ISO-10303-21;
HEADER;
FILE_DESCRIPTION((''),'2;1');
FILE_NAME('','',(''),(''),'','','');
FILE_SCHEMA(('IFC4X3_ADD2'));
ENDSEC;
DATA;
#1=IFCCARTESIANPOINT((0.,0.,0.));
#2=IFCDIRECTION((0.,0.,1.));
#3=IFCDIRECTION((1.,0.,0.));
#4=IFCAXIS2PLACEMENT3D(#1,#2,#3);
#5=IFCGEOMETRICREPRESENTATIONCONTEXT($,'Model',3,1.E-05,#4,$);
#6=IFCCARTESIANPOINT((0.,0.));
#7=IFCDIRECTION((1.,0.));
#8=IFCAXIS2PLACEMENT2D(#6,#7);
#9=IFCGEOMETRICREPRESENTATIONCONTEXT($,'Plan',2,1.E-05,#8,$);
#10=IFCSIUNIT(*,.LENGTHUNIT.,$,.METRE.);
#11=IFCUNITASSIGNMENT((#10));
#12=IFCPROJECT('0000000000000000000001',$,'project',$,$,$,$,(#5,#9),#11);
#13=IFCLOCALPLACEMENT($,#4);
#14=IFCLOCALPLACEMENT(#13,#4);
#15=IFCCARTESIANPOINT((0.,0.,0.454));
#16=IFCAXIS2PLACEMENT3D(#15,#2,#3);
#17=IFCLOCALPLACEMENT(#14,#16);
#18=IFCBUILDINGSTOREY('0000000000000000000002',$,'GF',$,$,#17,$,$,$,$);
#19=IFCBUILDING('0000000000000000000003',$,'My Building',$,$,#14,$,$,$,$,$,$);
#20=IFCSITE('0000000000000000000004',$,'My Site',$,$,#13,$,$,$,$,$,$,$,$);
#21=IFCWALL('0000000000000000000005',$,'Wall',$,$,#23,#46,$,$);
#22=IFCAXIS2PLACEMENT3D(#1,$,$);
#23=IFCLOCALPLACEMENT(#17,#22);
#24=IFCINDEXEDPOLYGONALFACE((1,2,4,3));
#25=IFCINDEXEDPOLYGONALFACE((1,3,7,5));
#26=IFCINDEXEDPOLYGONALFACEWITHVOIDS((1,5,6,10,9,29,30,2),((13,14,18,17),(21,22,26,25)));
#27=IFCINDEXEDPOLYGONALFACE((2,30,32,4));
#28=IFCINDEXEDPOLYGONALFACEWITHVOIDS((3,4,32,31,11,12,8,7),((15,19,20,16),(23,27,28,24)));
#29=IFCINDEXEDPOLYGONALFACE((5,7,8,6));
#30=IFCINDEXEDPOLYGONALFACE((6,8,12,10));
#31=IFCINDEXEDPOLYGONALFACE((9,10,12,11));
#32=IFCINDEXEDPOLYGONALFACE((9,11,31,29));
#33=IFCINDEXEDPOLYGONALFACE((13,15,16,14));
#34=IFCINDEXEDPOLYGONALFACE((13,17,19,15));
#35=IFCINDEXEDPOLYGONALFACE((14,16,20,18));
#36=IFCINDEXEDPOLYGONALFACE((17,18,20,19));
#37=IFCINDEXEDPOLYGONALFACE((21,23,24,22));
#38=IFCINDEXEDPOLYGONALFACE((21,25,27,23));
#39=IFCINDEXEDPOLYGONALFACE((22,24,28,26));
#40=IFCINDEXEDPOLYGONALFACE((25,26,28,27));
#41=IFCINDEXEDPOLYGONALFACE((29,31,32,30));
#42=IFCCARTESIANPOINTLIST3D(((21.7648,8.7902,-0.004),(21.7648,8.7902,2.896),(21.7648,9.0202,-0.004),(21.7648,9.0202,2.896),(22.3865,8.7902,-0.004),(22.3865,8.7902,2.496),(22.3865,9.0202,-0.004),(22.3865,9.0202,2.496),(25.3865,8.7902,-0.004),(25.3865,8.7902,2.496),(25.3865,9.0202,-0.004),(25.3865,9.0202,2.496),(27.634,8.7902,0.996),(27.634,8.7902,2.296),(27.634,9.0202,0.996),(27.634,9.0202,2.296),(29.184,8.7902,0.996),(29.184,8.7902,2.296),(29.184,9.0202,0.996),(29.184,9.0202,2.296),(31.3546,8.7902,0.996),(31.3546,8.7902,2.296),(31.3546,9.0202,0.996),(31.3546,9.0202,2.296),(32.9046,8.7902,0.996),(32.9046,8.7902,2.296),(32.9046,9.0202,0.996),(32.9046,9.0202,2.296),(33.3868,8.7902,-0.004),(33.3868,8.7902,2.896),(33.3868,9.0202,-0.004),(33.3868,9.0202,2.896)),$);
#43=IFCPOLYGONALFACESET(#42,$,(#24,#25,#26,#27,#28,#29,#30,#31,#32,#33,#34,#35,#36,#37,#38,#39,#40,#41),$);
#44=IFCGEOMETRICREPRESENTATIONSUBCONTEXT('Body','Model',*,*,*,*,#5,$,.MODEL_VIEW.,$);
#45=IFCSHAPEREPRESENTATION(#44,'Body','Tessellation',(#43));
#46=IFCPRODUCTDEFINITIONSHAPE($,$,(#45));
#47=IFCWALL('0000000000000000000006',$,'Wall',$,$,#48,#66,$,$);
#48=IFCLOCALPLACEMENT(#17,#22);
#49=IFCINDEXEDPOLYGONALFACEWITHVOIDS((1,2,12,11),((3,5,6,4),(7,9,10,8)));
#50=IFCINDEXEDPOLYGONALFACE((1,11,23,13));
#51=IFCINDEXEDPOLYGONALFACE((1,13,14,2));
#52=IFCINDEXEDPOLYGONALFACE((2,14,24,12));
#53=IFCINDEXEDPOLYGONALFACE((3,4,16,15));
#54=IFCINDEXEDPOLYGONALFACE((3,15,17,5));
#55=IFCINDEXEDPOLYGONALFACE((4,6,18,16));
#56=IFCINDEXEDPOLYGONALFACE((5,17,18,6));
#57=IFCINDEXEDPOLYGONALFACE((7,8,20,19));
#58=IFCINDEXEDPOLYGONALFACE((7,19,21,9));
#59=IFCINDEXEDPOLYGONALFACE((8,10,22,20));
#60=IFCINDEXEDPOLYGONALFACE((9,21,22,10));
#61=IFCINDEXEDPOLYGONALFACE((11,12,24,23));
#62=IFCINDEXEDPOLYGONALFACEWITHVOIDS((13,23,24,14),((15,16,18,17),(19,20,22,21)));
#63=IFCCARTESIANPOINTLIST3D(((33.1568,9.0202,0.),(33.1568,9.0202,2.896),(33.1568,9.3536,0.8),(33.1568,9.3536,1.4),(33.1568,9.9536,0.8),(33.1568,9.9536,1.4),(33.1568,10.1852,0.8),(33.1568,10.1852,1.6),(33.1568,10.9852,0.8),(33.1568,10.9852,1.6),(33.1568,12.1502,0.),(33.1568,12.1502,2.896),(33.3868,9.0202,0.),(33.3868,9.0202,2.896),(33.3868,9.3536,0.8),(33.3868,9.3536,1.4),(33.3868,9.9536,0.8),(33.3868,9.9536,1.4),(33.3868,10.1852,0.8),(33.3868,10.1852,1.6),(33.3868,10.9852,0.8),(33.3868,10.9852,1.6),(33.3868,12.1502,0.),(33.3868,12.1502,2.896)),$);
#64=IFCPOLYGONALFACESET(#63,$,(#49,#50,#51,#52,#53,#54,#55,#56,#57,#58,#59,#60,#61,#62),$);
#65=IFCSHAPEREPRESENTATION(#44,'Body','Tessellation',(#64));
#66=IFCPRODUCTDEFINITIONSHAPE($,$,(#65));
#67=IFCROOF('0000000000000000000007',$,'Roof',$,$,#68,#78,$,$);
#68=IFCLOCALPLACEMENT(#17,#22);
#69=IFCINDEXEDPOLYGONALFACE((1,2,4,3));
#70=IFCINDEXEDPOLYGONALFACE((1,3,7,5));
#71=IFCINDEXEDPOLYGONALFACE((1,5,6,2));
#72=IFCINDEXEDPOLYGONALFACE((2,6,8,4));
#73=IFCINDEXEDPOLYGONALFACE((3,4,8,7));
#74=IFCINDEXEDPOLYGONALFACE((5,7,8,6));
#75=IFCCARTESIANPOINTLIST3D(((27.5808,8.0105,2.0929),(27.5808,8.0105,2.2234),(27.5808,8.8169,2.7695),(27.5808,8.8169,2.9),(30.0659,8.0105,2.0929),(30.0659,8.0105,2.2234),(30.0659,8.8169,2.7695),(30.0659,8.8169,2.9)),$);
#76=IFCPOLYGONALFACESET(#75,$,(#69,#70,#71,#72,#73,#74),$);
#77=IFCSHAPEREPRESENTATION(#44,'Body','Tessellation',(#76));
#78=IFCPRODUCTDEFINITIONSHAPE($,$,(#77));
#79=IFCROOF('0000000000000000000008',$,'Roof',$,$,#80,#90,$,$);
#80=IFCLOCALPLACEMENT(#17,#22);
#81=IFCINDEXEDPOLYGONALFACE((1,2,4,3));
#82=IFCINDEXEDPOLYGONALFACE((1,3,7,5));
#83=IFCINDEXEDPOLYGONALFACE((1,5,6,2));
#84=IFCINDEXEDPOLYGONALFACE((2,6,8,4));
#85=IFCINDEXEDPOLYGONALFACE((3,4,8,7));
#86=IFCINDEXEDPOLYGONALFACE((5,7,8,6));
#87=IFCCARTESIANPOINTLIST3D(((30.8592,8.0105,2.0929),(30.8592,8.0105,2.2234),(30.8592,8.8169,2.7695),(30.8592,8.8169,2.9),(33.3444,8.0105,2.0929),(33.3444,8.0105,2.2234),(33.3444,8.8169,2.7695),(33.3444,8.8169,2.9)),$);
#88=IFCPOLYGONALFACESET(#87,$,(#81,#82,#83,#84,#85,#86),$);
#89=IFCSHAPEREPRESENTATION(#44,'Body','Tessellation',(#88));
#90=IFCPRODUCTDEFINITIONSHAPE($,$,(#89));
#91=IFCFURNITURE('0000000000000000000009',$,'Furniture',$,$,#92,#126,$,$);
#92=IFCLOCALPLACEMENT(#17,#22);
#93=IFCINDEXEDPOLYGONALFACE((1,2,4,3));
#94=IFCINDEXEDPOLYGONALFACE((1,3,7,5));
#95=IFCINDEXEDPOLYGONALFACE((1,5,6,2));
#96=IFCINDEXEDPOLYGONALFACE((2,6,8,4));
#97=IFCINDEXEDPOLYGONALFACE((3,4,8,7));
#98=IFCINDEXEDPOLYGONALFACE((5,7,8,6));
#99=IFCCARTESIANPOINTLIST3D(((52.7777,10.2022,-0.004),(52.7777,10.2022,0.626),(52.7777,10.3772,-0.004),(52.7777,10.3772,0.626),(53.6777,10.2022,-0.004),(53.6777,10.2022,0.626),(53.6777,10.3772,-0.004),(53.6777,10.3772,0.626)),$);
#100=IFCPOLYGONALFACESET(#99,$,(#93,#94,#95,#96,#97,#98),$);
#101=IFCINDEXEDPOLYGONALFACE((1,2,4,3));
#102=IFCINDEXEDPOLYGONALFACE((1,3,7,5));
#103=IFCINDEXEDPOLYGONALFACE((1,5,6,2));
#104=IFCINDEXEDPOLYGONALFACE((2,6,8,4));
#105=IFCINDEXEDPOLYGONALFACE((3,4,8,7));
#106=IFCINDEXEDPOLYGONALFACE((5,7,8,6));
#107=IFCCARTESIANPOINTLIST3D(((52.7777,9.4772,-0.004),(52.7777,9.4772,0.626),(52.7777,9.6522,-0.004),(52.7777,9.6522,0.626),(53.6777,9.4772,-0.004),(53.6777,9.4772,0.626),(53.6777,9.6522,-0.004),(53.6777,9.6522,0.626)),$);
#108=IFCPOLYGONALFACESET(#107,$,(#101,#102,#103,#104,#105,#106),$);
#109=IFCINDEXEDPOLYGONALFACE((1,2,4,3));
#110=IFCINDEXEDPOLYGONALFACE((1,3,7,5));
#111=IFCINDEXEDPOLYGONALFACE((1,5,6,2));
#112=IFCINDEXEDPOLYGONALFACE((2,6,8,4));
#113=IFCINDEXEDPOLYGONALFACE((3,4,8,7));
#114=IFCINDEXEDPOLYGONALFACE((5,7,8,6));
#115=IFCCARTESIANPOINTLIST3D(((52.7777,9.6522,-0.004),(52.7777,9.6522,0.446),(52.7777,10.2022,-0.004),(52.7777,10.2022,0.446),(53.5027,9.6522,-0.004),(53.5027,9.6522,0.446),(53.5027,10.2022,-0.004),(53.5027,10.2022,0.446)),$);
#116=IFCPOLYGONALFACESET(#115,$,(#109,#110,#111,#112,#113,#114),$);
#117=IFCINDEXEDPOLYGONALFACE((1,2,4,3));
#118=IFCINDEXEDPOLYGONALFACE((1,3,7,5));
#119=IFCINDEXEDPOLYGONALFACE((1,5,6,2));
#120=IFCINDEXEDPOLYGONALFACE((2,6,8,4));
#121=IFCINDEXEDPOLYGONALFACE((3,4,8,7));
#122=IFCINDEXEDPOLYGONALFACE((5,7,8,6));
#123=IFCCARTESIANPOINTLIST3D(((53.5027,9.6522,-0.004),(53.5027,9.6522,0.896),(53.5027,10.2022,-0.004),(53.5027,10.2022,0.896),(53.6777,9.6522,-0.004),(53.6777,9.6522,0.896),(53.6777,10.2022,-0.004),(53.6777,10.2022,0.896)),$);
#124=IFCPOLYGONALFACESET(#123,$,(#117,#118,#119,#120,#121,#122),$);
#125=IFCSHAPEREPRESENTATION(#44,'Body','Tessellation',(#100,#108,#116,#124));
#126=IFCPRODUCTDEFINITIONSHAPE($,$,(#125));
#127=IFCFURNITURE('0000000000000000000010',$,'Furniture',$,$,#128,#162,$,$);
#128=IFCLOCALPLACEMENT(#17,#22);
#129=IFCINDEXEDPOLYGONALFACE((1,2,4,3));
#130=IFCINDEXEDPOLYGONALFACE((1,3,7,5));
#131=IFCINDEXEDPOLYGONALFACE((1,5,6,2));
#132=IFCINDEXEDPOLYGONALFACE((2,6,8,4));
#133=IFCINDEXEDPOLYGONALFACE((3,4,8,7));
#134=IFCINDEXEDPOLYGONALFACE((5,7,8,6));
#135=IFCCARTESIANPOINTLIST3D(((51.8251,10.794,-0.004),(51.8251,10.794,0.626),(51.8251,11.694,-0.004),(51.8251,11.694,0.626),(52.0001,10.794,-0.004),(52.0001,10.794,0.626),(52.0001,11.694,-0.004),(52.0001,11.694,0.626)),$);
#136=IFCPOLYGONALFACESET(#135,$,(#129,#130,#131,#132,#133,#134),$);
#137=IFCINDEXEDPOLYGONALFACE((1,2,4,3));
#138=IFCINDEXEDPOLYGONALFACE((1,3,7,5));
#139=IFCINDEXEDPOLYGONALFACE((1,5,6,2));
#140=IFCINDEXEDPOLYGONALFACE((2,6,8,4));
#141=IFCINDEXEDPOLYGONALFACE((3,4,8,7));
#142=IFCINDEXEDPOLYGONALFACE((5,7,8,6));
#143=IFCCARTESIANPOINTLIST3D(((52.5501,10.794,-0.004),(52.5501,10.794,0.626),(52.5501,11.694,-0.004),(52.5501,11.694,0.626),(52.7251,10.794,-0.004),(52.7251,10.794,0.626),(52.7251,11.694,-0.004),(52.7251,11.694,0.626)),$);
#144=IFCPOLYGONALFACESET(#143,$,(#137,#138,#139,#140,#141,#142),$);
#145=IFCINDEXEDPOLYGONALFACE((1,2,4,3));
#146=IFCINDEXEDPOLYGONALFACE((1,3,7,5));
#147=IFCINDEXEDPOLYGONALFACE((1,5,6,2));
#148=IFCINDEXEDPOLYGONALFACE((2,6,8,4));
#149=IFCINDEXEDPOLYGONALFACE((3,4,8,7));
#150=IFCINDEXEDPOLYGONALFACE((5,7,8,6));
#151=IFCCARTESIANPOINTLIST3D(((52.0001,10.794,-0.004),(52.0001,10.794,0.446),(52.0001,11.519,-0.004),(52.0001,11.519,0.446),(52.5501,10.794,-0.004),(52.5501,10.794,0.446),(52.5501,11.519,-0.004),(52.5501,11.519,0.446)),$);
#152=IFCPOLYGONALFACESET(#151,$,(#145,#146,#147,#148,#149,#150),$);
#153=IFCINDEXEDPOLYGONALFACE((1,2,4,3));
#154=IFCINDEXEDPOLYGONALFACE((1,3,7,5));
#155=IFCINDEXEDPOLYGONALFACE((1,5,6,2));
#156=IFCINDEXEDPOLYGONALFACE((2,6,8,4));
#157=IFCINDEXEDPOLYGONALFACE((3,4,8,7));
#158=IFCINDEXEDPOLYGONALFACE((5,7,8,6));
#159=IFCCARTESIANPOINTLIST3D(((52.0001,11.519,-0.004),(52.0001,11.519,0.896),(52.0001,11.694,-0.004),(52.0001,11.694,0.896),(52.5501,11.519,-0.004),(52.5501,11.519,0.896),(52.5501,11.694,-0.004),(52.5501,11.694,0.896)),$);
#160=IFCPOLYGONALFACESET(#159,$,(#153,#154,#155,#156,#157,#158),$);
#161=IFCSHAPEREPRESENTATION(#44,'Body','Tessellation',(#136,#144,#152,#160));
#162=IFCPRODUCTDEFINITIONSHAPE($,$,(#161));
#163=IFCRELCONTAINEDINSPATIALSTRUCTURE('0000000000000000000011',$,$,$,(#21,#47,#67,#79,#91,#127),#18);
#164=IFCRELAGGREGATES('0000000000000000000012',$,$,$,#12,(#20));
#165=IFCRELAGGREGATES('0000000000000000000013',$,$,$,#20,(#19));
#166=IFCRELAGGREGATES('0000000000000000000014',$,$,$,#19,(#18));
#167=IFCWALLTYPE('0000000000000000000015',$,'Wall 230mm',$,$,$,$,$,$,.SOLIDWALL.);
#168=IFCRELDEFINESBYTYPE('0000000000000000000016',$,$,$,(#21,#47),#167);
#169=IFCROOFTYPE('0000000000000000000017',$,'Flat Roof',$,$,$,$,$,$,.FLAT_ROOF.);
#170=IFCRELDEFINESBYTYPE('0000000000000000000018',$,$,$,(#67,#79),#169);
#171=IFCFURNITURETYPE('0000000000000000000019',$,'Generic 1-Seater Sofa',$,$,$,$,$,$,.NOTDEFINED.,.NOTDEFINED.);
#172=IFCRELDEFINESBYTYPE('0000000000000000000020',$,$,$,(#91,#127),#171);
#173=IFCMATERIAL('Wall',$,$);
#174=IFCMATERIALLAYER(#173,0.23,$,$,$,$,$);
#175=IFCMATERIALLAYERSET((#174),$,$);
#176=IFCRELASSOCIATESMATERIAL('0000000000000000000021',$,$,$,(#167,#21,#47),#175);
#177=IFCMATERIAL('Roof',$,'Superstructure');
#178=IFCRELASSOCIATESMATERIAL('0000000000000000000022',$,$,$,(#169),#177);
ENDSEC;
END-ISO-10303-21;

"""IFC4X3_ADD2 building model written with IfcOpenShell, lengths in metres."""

from ifc_helpers import new_model, entity, si_unit, frame, origin_with_axes, origin_2d_with_axis, place, context, subcontext, project, spatial, polyline, line, indexed_curve, outline, extrude, clip, halfspace, shape, source, transform, mapped, material, layer, layer_set, layer_usage, type_object, type_shapes, element, save


model = new_model("IFC4X3_ADD2")

# Units and contexts
model_context = context("Model", 3, precision=1e-05, world=origin_with_axes())
plan_context = context("Plan", 2, precision=1e-05, world=origin_2d_with_axis())
body_context_1 = subcontext(model_context, "Body", "Model", "MODEL_VIEW")
body_context_2 = subcontext(plan_context, "Body", "Plan", "PLAN_VIEW")
ifc_project = project(units=[si_unit("LENGTHUNIT", "METRE")], contexts=[model_context, plan_context])

# Site, building, storey
site_placement = place(None, origin_with_axes())
site = spatial("IfcSite", under=ifc_project, at=site_placement, Name="My Site")
building_placement = place(site_placement, origin_with_axes())
building = spatial("IfcBuilding", under=site, at=building_placement, Name="My Building")
storey_placement = place(building_placement, frame((0.0, 0.0, 0.454), z_axis=(0.0, 0.0, 1.0), x_axis=(1.0, 0.0, 0.0)))
storey = spatial("IfcBuildingStorey", under=building, at=storey_placement, Name="GF")

# Walls, openings
ifc_material_1 = material(Name="Wall")
ifc_layer = layer(ifc_material_1, 0.23)
ifc_layer_set = layer_set([ifc_layer])
ifc_layer_usage_1 = layer_usage(ifc_layer_set, "AXIS2", "POSITIVE", 0.0)
wall_type = type_object("IfcWallType", Name="Wall 230mm", PredefinedType="SOLIDWALL", material=ifc_layer_set)
wall_1_placement = place(storey_placement, frame((33.3868, 9.0202, -0.004), z_axis=(0.0, 0.0, 1.0), x_axis=(-1.0, 0.0, 0.0)))
wall_1 = element("IfcWall", 1, at=wall_1_placement, inside=storey, type_object=wall_type, material=ifc_layer_usage_1, Name="Wall", context=body_context_1, shape_type="SweptSolid", body=[
    extrude(outline(indexed_curve([(0.0, 0.0), (0.0, 0.23), (11.622, 0.23), (11.622, 0.0), (0.0, 0.0)], self_intersect=False)), origin_with_axes(), (0.0, 0.0, 1.0), 2.9),
])
shared_shape_1 = source(origin_with_axes(), body_context_1, "Body", "SweptSolid", [
    extrude(outline(indexed_curve([(0.0, 0.0), (3.0, 0.0), (3.0, 2.5), (0.0, 2.5)], segments=[line(1, 2, 3, 4, 1)])), frame((0.0, -0.6, 0.0), z_axis=(0.0, -1.0, 0.0), x_axis=(1.0, 0.0, 0.0)), (0.0, 0.0, -1.0), 1.2),
])
opening_1_placement = place(wall_1_placement, frame((8.0003, 0.0, 0.0), z_axis=(0.0, 0.0, 1.0), x_axis=(1.0, 0.0, 0.0)))
element("IfcOpeningElement", 2, at=opening_1_placement, cuts=wall_1, PredefinedType="OPENING", context=body_context_1, shape_type="MappedRepresentation", body=[
    mapped(shared_shape_1, transform((0.0, 0.0, 0.0), x_axis=(1.0, 0.0, 0.0), y_axis=(0.0, 1.0, 0.0), z_axis=(0.0, 0.0, 1.0), scale=1.0)),
])
shared_shape_2 = source(origin_with_axes(), body_context_1, "Body", "SweptSolid", [
    extrude(outline(indexed_curve([(0.0, 0.0), (1.55, 0.0), (1.55, 1.3), (0.0, 1.3)], segments=[line(1, 2, 3, 4, 1)])), frame((-0.775, -0.6, 0.0), z_axis=(0.0, -1.0, 0.0), x_axis=(1.0, 0.0, 0.0)), (0.0, 0.0, -1.0), 1.2),
])
opening_2_placement = place(wall_1_placement, frame((1.2571, 0.0, 1.0), z_axis=(0.0, 0.0, 1.0), x_axis=(1.0, 0.0, 0.0)))
element("IfcOpeningElement", 3, at=opening_2_placement, cuts=wall_1, PredefinedType="OPENING", context=body_context_1, shape_type="MappedRepresentation", body=[
    mapped(shared_shape_2, transform((0.0, 0.0, 0.0), x_axis=(1.0, 0.0, 0.0), y_axis=(0.0, 1.0, 0.0), z_axis=(0.0, 0.0, 1.0), scale=1.0)),
])
opening_3_placement = place(wall_1_placement, frame((4.9778, 0.0, 1.0), z_axis=(0.0, 0.0, 1.0), x_axis=(1.0, 0.0, 0.0)))
element("IfcOpeningElement", 4, at=opening_3_placement, cuts=wall_1, PredefinedType="OPENING", context=body_context_1, shape_type="MappedRepresentation", body=[
    mapped(shared_shape_2, transform((0.0, 0.0, 0.0), x_axis=(1.0, 0.0, 0.0), y_axis=(0.0, 1.0, 0.0), z_axis=(0.0, 0.0, 1.0), scale=1.0)),
])
ifc_layer_usage_2 = layer_usage(ifc_layer_set, "AXIS2", "POSITIVE", 0.0)
wall_2_placement = place(storey_placement, frame((33.3868, 9.0202, 0.0), z_axis=(0.0, 0.0, 1.0), x_axis=(0.000001, 1.0, 0.0)))
wall_2 = element("IfcWall", 5, at=wall_2_placement, inside=storey, type_object=wall_type, material=ifc_layer_usage_2, Name="Wall", context=body_context_1, shape_type="Clipping", body=[
    clip(extrude(outline(indexed_curve([(0.0, 0.0), (0.0, 0.23), (3.13, 0.23), (3.13, 0.0), (0.0, 0.0)], self_intersect=False)), origin_with_axes(), (0.0, 0.0, 1.0), 3.35), halfspace(frame((0.0, 0.0, 2.896), z_axis=(0.0, 0.0, 1.0), x_axis=(-1.0, 0.0, 0.0)), False)),
])
shared_shape_3 = source(origin_with_axes(), body_context_1, "Body", "SweptSolid", [
    extrude(outline(indexed_curve([(0.0, 0.0), (0.6, 0.0), (0.6, 0.6), (0.0, 0.6)], segments=[line(1, 2, 3, 4, 1)])), frame((-0.3, -0.6, 0.0), z_axis=(0.0, -1.0, 0.0), x_axis=(1.0, 0.0, 0.0)), (0.0, 0.0, -1.0), 1.2),
])
opening_4_placement = place(wall_2_placement, frame((0.6334, 0.0, 0.8), z_axis=(0.0, 0.0, 1.0), x_axis=(1.0, 0.0, 0.0)))
element("IfcOpeningElement", 6, at=opening_4_placement, cuts=wall_2, PredefinedType="OPENING", context=body_context_1, shape_type="MappedRepresentation", body=[
    mapped(shared_shape_3, transform((0.0, 0.0, 0.0), x_axis=(1.0, 0.0, 0.0), y_axis=(0.0, 1.0, 0.0), z_axis=(0.0, 0.0, 1.0), scale=1.0)),
])
shared_shape_4 = source(origin_with_axes(), body_context_1, "Body", "SweptSolid", [
    extrude(outline(indexed_curve([(0.0, 0.0), (0.8, 0.0), (0.8, 0.8), (0.0, 0.8)], segments=[line(1, 2, 3, 4, 1)])), frame((-0.4, -0.6, 0.0), z_axis=(0.0, -1.0, 0.0), x_axis=(1.0, 0.0, 0.0)), (0.0, 0.0, -1.0), 1.2),
])
opening_5_placement = place(wall_2_placement, frame((1.565, 0.0, 0.8), z_axis=(0.0, 0.0, 1.0), x_axis=(1.0, 0.0, 0.0)))
element("IfcOpeningElement", 7, at=opening_5_placement, cuts=wall_2, PredefinedType="OPENING", context=body_context_1, shape_type="MappedRepresentation", body=[
    mapped(shared_shape_4, transform((0.0, 0.0, 0.0), x_axis=(1.0, 0.0, 0.0), y_axis=(0.0, 1.0, 0.0), z_axis=(0.0, 0.0, 1.0), scale=1.0)),
])

# Roofs
ifc_material_2 = material(Name="Roof", Category="Superstructure")
roof_type = type_object("IfcRoofType", Name="Flat Roof", PredefinedType="FLAT_ROOF", material=ifc_material_2)
for number, where, z_axis, x_axis, name in (
    (8, (27.5808, 8.0241, 2.1043), (0.0, -0.642788, 0.766044), (1.0, 0.0, 0.0), "Roof"),
    (9, (30.8592, 8.0241, 2.1043), (0.0, -0.642788, 0.766044), (1.0, 0.0, 0.0), "Roof"),
):
    element("IfcRoof", number, at=place(storey_placement, frame(where, z_axis=z_axis, x_axis=x_axis)), inside=storey, type_object=roof_type, Name=name, context=body_context_1, shape_type="SweptSolid", body=[
        extrude(outline(polyline([(-1.2426, -0.0653), (1.2426, -0.0653), (1.2426, 0.0653), (-1.2426, 0.0653), (-1.2426, -0.0653)])), frame((1.2426, 1.0768, 0.05), z_axis=(0.0, 0.766044, -0.642788), x_axis=(1.0, 0.0, 0.0)), (0.0, 0.642788, -0.766044), 1.0526),
    ])

# Furniture
furniture_type_1 = type_object("IfcFurnitureType", Name="Generic 1-Seater Sofa", AssemblyPlace="NOTDEFINED", PredefinedType="NOTDEFINED")
shared_shape_5 = source(origin_with_axes(), body_context_1, "Body", "SweptSolid", [
    extrude(outline(indexed_curve([(0.0, 0.0), (0.175, 0.0), (0.175, 0.9), (0.0, 0.9)], segments=[line(4, 1), line(1, 2), line(2, 3), line(3, 4)], self_intersect=False)), frame((-0.45, -0.9, 0.0), z_axis=(0.0, 0.0, 1.0), x_axis=(1.0, 0.0, 0.0)), (0.0, 0.0, 1.0), 0.63),
    extrude(outline(indexed_curve([(0.0, 0.0), (0.175, 0.0), (0.175, 0.9), (0.0, 0.9)], segments=[line(1, 2, 3, 4, 1)])), frame((0.275, -0.9, 0.0), z_axis=(0.0, 0.0, 1.0), x_axis=(1.0, 0.0, 0.0)), (0.0, 0.0, 1.0), 0.63),
    extrude(outline(indexed_curve([(0.175, 0.0), (0.725, 0.0), (0.725, 0.725), (0.175, 0.725)], segments=[line(1, 2, 3, 4, 1)])), frame((-0.45, -0.9, 0.0), z_axis=(0.0, 0.0, 1.0), x_axis=(1.0, 0.0, 0.0)), (0.0, 0.0, 1.0), 0.45),
    extrude(outline(indexed_curve([(0.175, 0.725), (0.725, 0.725), (0.725, 0.9), (0.175, 0.9)], segments=[line(1, 2, 3, 4, 1)])), frame((-0.45, -0.9, 0.0), z_axis=(0.0, 0.0, 1.0), x_axis=(1.0, 0.0, 0.0)), (0.0, 0.0, 1.0), 0.9),
])
shared_shape_6 = source(origin_with_axes(), body_context_2, "Body", "Annotation2D", [
    entity("IfcGeometricCurveSet", [entity("IfcIndexedPolyCurve", entity("IfcCartesianPointList2D", [[0.275, -0.175], [0.275, -0.9], [0.45, -0.9], [0.45, 0.0], [0.275, 0.0], [0.275, -0.9], [-0.275, -0.9], [-0.275, 0.0], [-0.275, -0.175], [0.275, -0.175], [0.275, 0.0], [-0.275, 0.0], [-0.45, 0.0], [-0.45, -0.9], [-0.275, -0.9], [-0.275, -0.175]]))]),
])
type_shapes(furniture_type_1, [shared_shape_5, shared_shape_6])
for number, where, z_axis, x_axis, name in (
    (10, (53.6777, 9.9272, -0.004), (0.0, 0.0, 1.0), (0.0, -1.0, 0.0), "Furniture"),
    (11, (52.2751, 11.694, -0.004), (0.0, 0.0, 1.0), (1.0, 0.0, 0.0), "Furniture"),
):
    element("IfcFurniture", number, at=place(storey_placement, frame(where, z_axis=z_axis, x_axis=x_axis)), inside=storey, type_object=furniture_type_1, Name=name, shapes=[
        shape(body_context_1, "Body", "MappedRepresentation", [mapped(shared_shape_5, transform((0.0, 0.0, 0.0), x_axis=(1.0, 0.0, 0.0), y_axis=(0.0, 1.0, 0.0), z_axis=(0.0, 0.0, 1.0), scale=1.0))]),
        shape(body_context_2, "Body", "MappedRepresentation", [mapped(shared_shape_6, transform((0.0, 0.0, 0.0), x_axis=(1.0, 0.0, 0.0), y_axis=(0.0, 1.0, 0.0), z_axis=(0.0, 0.0, 1.0), scale=1.0))]),
    ])

save(model, "model.ifc")
